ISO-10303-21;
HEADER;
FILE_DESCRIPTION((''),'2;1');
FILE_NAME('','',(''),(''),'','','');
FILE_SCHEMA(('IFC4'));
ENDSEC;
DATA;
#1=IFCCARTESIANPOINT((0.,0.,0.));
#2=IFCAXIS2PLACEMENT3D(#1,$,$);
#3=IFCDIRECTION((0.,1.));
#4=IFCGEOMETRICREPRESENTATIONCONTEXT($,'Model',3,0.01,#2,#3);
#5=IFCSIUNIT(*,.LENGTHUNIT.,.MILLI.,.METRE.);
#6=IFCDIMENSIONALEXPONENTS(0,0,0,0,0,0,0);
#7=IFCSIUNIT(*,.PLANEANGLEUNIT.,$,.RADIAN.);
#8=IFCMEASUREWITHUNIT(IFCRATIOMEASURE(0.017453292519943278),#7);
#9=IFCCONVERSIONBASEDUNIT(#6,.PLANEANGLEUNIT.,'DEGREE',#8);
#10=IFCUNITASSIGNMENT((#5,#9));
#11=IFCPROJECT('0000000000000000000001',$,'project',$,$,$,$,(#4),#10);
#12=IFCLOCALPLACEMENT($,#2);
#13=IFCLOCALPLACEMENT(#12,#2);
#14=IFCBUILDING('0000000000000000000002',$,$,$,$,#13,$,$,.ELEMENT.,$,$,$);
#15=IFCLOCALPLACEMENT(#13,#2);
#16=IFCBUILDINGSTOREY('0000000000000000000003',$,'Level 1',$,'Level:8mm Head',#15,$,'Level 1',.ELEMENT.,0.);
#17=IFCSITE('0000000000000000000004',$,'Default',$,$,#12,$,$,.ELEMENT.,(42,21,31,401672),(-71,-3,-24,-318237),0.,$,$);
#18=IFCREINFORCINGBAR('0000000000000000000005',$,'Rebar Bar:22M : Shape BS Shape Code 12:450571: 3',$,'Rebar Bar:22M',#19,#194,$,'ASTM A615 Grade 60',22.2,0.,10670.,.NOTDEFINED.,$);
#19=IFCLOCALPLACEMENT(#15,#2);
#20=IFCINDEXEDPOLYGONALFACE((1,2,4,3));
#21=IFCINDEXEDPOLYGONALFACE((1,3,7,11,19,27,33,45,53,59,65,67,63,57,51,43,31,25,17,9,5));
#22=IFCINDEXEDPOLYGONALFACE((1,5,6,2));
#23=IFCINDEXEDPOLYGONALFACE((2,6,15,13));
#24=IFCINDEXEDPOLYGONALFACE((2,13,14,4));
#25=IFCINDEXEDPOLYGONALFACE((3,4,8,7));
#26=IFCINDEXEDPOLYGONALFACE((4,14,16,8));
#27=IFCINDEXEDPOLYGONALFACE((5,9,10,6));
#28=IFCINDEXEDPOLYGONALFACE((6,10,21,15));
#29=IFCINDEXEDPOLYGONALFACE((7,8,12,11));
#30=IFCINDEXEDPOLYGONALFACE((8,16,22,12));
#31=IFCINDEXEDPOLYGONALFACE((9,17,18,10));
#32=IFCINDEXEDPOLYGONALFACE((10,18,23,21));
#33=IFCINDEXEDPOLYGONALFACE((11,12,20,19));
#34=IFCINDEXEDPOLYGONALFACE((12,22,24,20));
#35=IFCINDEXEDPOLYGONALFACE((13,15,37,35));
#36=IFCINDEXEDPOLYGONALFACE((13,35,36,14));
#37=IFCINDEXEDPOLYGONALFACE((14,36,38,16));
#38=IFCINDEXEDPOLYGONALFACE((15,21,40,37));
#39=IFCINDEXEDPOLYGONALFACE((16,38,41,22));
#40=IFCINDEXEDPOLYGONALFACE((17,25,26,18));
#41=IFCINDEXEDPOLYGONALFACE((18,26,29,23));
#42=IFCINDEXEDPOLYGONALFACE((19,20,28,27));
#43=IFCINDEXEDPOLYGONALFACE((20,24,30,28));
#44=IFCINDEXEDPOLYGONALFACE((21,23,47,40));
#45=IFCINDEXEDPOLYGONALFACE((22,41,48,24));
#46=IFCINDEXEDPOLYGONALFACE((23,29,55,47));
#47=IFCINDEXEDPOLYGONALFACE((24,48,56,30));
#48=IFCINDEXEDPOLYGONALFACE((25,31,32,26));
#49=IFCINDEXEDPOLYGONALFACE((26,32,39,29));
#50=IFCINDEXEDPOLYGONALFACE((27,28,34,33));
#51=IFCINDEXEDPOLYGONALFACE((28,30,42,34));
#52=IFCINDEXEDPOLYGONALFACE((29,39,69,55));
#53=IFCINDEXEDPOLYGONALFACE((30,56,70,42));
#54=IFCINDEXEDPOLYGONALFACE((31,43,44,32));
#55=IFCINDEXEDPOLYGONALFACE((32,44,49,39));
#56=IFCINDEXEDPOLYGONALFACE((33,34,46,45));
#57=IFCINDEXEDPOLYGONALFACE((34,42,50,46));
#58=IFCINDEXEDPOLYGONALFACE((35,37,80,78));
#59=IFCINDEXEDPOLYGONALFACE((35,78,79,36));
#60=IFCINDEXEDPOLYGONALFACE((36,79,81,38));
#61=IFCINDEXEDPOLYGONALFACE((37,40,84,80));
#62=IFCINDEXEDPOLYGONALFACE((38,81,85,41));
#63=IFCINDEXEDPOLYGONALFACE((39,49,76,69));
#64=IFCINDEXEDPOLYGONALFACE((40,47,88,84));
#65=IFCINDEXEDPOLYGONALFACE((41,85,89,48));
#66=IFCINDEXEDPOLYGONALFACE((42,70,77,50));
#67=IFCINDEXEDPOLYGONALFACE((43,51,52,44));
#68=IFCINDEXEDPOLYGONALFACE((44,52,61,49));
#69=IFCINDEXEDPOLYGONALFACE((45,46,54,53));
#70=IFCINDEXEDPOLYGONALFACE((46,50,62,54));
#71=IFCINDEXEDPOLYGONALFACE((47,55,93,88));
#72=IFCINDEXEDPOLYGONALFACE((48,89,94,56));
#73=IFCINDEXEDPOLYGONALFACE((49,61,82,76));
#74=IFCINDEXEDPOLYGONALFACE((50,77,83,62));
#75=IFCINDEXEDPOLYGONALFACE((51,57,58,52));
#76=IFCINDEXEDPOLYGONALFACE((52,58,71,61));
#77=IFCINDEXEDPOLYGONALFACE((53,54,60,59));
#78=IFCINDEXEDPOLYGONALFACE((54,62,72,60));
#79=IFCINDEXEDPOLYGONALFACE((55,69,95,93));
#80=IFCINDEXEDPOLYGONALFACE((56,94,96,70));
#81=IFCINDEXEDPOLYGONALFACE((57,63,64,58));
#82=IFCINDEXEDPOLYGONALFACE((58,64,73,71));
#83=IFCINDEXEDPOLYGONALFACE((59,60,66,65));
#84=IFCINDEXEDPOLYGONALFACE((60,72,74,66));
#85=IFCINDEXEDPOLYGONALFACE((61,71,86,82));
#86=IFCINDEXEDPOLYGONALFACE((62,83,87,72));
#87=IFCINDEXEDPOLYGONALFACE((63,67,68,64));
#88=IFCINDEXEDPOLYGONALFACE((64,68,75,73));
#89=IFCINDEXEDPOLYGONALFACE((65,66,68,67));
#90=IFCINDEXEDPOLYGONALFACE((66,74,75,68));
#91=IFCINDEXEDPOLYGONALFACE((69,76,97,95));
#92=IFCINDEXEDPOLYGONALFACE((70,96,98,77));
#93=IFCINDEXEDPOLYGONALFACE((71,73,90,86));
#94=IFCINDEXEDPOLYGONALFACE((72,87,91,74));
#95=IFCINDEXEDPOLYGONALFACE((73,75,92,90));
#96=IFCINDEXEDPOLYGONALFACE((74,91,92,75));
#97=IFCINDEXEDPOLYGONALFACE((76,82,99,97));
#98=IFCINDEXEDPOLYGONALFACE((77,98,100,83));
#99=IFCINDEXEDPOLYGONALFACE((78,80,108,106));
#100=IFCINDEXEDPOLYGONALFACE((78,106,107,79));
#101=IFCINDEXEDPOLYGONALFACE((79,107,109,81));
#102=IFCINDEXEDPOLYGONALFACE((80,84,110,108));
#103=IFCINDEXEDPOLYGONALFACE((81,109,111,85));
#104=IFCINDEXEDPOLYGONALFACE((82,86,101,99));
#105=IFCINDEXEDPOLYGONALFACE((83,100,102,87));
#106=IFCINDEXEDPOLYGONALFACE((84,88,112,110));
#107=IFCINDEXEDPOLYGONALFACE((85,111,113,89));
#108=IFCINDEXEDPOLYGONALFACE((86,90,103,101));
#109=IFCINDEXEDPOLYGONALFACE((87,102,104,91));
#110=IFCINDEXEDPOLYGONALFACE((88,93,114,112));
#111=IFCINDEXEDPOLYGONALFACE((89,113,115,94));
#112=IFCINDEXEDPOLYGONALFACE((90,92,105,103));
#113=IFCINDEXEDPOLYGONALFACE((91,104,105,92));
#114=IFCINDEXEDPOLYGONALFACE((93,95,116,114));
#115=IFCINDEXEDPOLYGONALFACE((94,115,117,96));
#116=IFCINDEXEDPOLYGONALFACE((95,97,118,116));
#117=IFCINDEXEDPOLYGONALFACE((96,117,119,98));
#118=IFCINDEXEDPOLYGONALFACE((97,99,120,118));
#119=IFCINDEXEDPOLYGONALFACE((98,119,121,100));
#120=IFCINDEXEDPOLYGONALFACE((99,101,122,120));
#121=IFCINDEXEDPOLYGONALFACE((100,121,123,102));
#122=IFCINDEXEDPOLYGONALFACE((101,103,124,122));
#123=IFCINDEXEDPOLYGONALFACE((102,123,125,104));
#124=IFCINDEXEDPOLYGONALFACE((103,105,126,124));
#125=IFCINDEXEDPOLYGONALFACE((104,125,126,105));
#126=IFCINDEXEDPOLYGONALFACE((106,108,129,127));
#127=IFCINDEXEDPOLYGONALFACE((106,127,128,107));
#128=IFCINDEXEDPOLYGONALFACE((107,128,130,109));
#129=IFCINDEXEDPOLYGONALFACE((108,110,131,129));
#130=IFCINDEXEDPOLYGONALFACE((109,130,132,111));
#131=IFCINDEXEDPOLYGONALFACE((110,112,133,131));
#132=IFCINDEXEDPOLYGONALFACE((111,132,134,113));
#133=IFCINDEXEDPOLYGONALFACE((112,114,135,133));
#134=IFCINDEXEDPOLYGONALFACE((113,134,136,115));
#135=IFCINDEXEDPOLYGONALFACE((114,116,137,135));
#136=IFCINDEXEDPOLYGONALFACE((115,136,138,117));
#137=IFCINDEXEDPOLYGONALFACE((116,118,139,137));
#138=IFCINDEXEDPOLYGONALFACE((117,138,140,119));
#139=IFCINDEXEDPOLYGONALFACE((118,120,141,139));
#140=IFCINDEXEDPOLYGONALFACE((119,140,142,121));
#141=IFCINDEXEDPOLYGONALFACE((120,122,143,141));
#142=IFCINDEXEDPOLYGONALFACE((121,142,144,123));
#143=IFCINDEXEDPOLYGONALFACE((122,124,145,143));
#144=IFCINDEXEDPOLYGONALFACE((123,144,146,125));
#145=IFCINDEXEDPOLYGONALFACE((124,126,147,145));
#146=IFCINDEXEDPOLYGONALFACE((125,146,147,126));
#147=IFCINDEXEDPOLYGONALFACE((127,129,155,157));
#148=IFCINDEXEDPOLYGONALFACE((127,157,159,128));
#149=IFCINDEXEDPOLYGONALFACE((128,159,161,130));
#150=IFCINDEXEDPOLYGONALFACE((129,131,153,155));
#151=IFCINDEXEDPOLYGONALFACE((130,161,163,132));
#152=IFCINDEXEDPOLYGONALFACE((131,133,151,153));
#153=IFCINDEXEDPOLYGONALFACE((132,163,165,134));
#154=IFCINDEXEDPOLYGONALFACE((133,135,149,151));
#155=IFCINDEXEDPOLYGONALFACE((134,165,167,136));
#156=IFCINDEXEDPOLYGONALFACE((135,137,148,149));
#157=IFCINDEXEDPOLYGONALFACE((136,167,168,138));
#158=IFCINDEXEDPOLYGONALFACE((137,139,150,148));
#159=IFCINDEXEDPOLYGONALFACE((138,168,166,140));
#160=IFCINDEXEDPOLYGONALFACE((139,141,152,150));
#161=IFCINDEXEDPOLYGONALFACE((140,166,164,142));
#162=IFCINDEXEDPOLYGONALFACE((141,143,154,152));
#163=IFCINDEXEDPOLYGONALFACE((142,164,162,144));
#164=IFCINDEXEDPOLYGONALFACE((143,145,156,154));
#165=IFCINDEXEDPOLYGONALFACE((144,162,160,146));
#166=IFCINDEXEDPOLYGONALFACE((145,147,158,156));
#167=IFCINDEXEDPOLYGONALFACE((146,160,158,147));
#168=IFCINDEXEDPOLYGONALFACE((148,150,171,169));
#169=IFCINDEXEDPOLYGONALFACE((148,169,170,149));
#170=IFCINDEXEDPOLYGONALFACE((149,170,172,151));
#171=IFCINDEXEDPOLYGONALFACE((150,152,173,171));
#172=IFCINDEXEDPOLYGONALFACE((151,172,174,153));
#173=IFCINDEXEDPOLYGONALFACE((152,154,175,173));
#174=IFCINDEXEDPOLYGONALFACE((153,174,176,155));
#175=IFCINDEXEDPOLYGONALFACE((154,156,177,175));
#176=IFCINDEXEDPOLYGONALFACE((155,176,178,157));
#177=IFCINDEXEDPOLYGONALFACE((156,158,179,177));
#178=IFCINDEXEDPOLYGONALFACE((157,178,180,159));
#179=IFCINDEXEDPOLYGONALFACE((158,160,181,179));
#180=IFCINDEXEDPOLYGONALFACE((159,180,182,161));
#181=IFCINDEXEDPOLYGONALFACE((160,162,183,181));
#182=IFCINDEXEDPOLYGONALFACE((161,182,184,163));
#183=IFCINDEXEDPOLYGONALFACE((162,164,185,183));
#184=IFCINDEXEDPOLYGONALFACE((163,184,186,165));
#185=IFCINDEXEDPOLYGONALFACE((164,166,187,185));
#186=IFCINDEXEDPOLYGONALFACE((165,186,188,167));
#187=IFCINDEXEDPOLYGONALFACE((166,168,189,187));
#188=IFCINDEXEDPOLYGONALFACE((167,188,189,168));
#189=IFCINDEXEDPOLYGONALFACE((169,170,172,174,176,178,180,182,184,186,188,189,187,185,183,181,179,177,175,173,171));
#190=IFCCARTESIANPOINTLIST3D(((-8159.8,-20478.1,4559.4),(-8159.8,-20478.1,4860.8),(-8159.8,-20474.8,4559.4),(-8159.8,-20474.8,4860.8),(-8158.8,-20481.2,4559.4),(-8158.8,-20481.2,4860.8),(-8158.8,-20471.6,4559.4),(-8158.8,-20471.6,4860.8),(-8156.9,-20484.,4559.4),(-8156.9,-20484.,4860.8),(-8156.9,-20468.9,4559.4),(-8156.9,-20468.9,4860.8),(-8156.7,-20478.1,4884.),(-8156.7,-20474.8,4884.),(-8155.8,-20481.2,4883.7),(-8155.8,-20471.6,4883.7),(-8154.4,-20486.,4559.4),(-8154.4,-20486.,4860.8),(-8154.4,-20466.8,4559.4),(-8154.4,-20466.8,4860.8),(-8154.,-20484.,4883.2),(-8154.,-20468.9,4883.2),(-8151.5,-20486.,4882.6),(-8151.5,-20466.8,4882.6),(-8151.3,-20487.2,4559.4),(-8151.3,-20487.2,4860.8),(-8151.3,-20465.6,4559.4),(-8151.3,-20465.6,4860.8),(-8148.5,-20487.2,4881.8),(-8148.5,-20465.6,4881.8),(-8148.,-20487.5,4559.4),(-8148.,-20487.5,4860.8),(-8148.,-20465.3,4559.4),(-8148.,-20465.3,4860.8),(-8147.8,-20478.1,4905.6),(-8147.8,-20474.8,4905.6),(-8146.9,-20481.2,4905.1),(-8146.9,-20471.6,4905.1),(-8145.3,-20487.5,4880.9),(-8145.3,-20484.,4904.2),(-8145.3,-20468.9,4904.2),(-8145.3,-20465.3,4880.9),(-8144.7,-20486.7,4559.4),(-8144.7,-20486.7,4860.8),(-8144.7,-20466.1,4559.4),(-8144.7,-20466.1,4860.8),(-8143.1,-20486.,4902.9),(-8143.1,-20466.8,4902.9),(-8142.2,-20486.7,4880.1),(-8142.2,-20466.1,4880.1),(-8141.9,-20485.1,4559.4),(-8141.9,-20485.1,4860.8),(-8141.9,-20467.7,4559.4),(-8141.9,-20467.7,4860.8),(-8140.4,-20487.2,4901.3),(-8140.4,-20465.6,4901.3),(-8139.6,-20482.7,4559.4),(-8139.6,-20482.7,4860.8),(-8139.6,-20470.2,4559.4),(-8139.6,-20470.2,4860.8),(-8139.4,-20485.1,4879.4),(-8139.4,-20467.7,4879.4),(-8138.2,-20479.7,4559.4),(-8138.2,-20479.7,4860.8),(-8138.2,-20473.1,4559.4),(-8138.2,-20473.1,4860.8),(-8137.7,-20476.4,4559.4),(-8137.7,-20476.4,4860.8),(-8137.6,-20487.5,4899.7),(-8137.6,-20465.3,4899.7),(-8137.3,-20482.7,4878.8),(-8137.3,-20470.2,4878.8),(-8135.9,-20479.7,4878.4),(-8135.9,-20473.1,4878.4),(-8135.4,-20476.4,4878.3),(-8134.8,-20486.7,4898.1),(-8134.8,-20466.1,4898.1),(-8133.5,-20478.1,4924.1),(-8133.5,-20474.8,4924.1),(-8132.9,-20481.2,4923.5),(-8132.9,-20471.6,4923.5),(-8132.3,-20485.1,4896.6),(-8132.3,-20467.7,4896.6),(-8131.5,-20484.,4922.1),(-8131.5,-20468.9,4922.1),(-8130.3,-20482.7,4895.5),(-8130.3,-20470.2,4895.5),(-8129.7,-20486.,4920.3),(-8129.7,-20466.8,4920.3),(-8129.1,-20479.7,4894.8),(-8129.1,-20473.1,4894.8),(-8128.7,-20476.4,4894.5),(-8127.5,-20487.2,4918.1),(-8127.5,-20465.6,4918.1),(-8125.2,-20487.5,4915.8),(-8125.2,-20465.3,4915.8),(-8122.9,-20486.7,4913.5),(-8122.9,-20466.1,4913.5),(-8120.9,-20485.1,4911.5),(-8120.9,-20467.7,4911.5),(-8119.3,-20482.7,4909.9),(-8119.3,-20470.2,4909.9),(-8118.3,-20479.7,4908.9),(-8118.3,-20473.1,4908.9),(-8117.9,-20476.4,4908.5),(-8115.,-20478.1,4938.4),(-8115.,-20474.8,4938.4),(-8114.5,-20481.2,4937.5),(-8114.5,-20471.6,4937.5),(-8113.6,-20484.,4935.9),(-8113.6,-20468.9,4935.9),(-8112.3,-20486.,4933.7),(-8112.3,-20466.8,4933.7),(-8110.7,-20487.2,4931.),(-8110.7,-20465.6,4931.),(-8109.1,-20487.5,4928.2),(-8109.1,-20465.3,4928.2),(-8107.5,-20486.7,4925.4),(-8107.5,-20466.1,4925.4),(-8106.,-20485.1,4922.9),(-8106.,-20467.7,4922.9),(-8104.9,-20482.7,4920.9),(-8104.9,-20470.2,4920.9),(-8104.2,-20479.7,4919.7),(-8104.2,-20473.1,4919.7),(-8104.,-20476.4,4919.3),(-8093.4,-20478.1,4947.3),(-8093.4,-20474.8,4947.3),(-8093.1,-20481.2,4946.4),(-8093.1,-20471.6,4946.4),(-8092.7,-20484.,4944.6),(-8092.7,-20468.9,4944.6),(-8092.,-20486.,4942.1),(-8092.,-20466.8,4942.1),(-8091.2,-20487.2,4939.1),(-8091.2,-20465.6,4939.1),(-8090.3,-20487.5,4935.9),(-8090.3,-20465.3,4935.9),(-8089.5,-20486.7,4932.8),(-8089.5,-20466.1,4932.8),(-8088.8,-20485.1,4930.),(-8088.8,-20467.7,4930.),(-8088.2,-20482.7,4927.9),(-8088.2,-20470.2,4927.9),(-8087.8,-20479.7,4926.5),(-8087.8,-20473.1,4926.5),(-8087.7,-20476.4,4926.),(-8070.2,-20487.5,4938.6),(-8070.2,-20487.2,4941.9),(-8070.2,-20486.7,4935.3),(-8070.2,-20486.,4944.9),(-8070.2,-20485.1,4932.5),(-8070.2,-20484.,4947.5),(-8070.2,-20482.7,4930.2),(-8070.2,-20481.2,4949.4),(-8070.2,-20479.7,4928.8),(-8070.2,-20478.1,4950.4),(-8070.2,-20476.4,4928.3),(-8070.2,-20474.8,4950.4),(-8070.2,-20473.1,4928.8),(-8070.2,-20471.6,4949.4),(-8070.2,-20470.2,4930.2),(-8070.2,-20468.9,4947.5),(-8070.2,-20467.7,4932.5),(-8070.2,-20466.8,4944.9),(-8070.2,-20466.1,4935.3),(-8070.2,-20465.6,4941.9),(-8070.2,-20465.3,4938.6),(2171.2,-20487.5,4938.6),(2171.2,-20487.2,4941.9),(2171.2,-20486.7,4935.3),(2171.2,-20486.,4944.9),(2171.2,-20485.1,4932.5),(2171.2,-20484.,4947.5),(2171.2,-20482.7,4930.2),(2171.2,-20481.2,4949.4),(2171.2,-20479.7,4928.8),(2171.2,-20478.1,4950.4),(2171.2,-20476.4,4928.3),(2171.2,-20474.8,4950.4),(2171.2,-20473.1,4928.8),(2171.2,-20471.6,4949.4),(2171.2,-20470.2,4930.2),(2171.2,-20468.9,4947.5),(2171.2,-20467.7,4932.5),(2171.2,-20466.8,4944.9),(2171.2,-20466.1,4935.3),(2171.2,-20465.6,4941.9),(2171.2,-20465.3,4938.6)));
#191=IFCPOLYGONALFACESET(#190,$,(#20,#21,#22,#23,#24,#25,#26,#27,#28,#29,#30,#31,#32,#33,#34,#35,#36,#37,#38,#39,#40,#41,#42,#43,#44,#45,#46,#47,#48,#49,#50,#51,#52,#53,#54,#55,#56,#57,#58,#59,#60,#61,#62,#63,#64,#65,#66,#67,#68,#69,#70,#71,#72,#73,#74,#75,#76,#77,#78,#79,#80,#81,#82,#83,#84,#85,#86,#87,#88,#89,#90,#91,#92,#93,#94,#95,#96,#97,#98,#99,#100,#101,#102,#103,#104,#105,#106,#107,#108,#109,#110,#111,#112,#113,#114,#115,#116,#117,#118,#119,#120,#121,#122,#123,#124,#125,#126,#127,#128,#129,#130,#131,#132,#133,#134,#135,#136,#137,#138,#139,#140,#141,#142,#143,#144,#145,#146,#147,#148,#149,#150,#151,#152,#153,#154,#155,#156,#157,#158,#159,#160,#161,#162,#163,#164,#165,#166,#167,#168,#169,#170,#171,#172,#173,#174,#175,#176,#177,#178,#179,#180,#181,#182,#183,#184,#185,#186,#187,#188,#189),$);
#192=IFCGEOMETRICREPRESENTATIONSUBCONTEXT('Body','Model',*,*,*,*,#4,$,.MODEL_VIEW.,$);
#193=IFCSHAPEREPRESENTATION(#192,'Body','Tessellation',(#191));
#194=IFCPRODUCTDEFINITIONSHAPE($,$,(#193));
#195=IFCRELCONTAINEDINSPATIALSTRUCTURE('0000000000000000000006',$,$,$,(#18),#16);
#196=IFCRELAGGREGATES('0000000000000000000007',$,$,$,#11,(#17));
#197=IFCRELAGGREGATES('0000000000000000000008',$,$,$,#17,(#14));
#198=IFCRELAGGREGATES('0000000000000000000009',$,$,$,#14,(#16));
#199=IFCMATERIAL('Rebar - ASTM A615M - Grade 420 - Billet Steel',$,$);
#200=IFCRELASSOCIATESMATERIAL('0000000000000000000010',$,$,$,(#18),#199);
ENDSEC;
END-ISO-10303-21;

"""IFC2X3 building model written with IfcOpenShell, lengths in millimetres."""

from ifc_helpers import new_model, entity, si_unit, converted_unit, direction, origin, place, context, subcontext, project, spatial, material, element, save


model = new_model("IFC2X3")

# Units and contexts
model_context = context("Model", 3, precision=0.01, world=origin(), true_north=direction((0.0, 1.0)))
body_context = subcontext(model_context, "Body", "Model", "MODEL_VIEW")
ifc_project = project(units=[si_unit("LENGTHUNIT", "METRE", prefix="MILLI"), converted_unit("PLANEANGLEUNIT", "DEGREE", entity("IfcRatioMeasure", 0.017453292519943278), si_unit("PLANEANGLEUNIT", "RADIAN"), dimensions=[0, 0, 0, 0, 0, 0, 0])], contexts=[model_context])

# Site, building, storey
site_placement = place(None, origin())
site = spatial("IfcSite", under=ifc_project, at=site_placement, Name="Default", CompositionType="ELEMENT", RefLatitude=(42, 21, 31, 401672), RefLongitude=(-71, -3, -24, -318237), RefElevation=0.0)
building_placement = place(site_placement, origin())
building = spatial("IfcBuilding", under=site, at=building_placement, CompositionType="ELEMENT")
storey_placement = place(building_placement, origin())
storey = spatial("IfcBuildingStorey", under=building, at=storey_placement, Name="Level 1", ObjectType="Level:8mm Head", LongName="Level 1", CompositionType="ELEMENT", Elevation=0.0)

# Reinforcing bar
ifc_material = material(Name="Rebar - ASTM A615M - Grade 420 - Billet Steel")
reinforcing_bar_1_placement = place(storey_placement, origin())
element("IfcReinforcingBar", 1, at=reinforcing_bar_1_placement, inside=storey, material=ifc_material, Name="Rebar Bar:22M : Shape BS Shape Code 12:450571: 3", SteelGrade="ASTM A615 Grade 60", ObjectType="Rebar Bar:22M", BarLength=10670.0, BarRole="NOTDEFINED", CrossSectionArea=0.0, NominalDiameter=22.2, context=body_context, shape_type="AdvancedSweptSolid", body=[
    entity("IfcSweptDiskSolid", entity("IfcCompositeCurve", [entity("IfcCompositeCurveSegment", "CONTINUOUS", True, entity("IfcPolyline", [entity("IfcCartesianPoint", [2171.2, -20476.4, 4939.4]), entity("IfcCartesianPoint", [-8070.2, -20476.4, 4939.4])])), entity("IfcCompositeCurveSegment", "CONTINUOUS", True, entity("IfcTrimmedCurve", entity("IfcCircle", entity("IfcAxis2Placement3D", entity("IfcCartesianPoint", [-8070.2, -20476.4, 4860.8]), entity("IfcDirection", [0.0, -1.0, 0.0]), entity("IfcDirection", [-1.0, 0.0, 0.0])), 78.6), [entity("IfcParameterValue", 270.0)], [entity("IfcParameterValue", 360.0)], True, "PARAMETER")), entity("IfcCompositeCurveSegment", "CONTINUOUS", True, entity("IfcPolyline", [entity("IfcCartesianPoint", [-8148.8, -20476.4, 4860.8]), entity("IfcCartesianPoint", [-8148.8, -20476.4, 4559.4])]))], False), 11.1, None, 0.0, 92.0),
])

save(model, "model.ifc")
